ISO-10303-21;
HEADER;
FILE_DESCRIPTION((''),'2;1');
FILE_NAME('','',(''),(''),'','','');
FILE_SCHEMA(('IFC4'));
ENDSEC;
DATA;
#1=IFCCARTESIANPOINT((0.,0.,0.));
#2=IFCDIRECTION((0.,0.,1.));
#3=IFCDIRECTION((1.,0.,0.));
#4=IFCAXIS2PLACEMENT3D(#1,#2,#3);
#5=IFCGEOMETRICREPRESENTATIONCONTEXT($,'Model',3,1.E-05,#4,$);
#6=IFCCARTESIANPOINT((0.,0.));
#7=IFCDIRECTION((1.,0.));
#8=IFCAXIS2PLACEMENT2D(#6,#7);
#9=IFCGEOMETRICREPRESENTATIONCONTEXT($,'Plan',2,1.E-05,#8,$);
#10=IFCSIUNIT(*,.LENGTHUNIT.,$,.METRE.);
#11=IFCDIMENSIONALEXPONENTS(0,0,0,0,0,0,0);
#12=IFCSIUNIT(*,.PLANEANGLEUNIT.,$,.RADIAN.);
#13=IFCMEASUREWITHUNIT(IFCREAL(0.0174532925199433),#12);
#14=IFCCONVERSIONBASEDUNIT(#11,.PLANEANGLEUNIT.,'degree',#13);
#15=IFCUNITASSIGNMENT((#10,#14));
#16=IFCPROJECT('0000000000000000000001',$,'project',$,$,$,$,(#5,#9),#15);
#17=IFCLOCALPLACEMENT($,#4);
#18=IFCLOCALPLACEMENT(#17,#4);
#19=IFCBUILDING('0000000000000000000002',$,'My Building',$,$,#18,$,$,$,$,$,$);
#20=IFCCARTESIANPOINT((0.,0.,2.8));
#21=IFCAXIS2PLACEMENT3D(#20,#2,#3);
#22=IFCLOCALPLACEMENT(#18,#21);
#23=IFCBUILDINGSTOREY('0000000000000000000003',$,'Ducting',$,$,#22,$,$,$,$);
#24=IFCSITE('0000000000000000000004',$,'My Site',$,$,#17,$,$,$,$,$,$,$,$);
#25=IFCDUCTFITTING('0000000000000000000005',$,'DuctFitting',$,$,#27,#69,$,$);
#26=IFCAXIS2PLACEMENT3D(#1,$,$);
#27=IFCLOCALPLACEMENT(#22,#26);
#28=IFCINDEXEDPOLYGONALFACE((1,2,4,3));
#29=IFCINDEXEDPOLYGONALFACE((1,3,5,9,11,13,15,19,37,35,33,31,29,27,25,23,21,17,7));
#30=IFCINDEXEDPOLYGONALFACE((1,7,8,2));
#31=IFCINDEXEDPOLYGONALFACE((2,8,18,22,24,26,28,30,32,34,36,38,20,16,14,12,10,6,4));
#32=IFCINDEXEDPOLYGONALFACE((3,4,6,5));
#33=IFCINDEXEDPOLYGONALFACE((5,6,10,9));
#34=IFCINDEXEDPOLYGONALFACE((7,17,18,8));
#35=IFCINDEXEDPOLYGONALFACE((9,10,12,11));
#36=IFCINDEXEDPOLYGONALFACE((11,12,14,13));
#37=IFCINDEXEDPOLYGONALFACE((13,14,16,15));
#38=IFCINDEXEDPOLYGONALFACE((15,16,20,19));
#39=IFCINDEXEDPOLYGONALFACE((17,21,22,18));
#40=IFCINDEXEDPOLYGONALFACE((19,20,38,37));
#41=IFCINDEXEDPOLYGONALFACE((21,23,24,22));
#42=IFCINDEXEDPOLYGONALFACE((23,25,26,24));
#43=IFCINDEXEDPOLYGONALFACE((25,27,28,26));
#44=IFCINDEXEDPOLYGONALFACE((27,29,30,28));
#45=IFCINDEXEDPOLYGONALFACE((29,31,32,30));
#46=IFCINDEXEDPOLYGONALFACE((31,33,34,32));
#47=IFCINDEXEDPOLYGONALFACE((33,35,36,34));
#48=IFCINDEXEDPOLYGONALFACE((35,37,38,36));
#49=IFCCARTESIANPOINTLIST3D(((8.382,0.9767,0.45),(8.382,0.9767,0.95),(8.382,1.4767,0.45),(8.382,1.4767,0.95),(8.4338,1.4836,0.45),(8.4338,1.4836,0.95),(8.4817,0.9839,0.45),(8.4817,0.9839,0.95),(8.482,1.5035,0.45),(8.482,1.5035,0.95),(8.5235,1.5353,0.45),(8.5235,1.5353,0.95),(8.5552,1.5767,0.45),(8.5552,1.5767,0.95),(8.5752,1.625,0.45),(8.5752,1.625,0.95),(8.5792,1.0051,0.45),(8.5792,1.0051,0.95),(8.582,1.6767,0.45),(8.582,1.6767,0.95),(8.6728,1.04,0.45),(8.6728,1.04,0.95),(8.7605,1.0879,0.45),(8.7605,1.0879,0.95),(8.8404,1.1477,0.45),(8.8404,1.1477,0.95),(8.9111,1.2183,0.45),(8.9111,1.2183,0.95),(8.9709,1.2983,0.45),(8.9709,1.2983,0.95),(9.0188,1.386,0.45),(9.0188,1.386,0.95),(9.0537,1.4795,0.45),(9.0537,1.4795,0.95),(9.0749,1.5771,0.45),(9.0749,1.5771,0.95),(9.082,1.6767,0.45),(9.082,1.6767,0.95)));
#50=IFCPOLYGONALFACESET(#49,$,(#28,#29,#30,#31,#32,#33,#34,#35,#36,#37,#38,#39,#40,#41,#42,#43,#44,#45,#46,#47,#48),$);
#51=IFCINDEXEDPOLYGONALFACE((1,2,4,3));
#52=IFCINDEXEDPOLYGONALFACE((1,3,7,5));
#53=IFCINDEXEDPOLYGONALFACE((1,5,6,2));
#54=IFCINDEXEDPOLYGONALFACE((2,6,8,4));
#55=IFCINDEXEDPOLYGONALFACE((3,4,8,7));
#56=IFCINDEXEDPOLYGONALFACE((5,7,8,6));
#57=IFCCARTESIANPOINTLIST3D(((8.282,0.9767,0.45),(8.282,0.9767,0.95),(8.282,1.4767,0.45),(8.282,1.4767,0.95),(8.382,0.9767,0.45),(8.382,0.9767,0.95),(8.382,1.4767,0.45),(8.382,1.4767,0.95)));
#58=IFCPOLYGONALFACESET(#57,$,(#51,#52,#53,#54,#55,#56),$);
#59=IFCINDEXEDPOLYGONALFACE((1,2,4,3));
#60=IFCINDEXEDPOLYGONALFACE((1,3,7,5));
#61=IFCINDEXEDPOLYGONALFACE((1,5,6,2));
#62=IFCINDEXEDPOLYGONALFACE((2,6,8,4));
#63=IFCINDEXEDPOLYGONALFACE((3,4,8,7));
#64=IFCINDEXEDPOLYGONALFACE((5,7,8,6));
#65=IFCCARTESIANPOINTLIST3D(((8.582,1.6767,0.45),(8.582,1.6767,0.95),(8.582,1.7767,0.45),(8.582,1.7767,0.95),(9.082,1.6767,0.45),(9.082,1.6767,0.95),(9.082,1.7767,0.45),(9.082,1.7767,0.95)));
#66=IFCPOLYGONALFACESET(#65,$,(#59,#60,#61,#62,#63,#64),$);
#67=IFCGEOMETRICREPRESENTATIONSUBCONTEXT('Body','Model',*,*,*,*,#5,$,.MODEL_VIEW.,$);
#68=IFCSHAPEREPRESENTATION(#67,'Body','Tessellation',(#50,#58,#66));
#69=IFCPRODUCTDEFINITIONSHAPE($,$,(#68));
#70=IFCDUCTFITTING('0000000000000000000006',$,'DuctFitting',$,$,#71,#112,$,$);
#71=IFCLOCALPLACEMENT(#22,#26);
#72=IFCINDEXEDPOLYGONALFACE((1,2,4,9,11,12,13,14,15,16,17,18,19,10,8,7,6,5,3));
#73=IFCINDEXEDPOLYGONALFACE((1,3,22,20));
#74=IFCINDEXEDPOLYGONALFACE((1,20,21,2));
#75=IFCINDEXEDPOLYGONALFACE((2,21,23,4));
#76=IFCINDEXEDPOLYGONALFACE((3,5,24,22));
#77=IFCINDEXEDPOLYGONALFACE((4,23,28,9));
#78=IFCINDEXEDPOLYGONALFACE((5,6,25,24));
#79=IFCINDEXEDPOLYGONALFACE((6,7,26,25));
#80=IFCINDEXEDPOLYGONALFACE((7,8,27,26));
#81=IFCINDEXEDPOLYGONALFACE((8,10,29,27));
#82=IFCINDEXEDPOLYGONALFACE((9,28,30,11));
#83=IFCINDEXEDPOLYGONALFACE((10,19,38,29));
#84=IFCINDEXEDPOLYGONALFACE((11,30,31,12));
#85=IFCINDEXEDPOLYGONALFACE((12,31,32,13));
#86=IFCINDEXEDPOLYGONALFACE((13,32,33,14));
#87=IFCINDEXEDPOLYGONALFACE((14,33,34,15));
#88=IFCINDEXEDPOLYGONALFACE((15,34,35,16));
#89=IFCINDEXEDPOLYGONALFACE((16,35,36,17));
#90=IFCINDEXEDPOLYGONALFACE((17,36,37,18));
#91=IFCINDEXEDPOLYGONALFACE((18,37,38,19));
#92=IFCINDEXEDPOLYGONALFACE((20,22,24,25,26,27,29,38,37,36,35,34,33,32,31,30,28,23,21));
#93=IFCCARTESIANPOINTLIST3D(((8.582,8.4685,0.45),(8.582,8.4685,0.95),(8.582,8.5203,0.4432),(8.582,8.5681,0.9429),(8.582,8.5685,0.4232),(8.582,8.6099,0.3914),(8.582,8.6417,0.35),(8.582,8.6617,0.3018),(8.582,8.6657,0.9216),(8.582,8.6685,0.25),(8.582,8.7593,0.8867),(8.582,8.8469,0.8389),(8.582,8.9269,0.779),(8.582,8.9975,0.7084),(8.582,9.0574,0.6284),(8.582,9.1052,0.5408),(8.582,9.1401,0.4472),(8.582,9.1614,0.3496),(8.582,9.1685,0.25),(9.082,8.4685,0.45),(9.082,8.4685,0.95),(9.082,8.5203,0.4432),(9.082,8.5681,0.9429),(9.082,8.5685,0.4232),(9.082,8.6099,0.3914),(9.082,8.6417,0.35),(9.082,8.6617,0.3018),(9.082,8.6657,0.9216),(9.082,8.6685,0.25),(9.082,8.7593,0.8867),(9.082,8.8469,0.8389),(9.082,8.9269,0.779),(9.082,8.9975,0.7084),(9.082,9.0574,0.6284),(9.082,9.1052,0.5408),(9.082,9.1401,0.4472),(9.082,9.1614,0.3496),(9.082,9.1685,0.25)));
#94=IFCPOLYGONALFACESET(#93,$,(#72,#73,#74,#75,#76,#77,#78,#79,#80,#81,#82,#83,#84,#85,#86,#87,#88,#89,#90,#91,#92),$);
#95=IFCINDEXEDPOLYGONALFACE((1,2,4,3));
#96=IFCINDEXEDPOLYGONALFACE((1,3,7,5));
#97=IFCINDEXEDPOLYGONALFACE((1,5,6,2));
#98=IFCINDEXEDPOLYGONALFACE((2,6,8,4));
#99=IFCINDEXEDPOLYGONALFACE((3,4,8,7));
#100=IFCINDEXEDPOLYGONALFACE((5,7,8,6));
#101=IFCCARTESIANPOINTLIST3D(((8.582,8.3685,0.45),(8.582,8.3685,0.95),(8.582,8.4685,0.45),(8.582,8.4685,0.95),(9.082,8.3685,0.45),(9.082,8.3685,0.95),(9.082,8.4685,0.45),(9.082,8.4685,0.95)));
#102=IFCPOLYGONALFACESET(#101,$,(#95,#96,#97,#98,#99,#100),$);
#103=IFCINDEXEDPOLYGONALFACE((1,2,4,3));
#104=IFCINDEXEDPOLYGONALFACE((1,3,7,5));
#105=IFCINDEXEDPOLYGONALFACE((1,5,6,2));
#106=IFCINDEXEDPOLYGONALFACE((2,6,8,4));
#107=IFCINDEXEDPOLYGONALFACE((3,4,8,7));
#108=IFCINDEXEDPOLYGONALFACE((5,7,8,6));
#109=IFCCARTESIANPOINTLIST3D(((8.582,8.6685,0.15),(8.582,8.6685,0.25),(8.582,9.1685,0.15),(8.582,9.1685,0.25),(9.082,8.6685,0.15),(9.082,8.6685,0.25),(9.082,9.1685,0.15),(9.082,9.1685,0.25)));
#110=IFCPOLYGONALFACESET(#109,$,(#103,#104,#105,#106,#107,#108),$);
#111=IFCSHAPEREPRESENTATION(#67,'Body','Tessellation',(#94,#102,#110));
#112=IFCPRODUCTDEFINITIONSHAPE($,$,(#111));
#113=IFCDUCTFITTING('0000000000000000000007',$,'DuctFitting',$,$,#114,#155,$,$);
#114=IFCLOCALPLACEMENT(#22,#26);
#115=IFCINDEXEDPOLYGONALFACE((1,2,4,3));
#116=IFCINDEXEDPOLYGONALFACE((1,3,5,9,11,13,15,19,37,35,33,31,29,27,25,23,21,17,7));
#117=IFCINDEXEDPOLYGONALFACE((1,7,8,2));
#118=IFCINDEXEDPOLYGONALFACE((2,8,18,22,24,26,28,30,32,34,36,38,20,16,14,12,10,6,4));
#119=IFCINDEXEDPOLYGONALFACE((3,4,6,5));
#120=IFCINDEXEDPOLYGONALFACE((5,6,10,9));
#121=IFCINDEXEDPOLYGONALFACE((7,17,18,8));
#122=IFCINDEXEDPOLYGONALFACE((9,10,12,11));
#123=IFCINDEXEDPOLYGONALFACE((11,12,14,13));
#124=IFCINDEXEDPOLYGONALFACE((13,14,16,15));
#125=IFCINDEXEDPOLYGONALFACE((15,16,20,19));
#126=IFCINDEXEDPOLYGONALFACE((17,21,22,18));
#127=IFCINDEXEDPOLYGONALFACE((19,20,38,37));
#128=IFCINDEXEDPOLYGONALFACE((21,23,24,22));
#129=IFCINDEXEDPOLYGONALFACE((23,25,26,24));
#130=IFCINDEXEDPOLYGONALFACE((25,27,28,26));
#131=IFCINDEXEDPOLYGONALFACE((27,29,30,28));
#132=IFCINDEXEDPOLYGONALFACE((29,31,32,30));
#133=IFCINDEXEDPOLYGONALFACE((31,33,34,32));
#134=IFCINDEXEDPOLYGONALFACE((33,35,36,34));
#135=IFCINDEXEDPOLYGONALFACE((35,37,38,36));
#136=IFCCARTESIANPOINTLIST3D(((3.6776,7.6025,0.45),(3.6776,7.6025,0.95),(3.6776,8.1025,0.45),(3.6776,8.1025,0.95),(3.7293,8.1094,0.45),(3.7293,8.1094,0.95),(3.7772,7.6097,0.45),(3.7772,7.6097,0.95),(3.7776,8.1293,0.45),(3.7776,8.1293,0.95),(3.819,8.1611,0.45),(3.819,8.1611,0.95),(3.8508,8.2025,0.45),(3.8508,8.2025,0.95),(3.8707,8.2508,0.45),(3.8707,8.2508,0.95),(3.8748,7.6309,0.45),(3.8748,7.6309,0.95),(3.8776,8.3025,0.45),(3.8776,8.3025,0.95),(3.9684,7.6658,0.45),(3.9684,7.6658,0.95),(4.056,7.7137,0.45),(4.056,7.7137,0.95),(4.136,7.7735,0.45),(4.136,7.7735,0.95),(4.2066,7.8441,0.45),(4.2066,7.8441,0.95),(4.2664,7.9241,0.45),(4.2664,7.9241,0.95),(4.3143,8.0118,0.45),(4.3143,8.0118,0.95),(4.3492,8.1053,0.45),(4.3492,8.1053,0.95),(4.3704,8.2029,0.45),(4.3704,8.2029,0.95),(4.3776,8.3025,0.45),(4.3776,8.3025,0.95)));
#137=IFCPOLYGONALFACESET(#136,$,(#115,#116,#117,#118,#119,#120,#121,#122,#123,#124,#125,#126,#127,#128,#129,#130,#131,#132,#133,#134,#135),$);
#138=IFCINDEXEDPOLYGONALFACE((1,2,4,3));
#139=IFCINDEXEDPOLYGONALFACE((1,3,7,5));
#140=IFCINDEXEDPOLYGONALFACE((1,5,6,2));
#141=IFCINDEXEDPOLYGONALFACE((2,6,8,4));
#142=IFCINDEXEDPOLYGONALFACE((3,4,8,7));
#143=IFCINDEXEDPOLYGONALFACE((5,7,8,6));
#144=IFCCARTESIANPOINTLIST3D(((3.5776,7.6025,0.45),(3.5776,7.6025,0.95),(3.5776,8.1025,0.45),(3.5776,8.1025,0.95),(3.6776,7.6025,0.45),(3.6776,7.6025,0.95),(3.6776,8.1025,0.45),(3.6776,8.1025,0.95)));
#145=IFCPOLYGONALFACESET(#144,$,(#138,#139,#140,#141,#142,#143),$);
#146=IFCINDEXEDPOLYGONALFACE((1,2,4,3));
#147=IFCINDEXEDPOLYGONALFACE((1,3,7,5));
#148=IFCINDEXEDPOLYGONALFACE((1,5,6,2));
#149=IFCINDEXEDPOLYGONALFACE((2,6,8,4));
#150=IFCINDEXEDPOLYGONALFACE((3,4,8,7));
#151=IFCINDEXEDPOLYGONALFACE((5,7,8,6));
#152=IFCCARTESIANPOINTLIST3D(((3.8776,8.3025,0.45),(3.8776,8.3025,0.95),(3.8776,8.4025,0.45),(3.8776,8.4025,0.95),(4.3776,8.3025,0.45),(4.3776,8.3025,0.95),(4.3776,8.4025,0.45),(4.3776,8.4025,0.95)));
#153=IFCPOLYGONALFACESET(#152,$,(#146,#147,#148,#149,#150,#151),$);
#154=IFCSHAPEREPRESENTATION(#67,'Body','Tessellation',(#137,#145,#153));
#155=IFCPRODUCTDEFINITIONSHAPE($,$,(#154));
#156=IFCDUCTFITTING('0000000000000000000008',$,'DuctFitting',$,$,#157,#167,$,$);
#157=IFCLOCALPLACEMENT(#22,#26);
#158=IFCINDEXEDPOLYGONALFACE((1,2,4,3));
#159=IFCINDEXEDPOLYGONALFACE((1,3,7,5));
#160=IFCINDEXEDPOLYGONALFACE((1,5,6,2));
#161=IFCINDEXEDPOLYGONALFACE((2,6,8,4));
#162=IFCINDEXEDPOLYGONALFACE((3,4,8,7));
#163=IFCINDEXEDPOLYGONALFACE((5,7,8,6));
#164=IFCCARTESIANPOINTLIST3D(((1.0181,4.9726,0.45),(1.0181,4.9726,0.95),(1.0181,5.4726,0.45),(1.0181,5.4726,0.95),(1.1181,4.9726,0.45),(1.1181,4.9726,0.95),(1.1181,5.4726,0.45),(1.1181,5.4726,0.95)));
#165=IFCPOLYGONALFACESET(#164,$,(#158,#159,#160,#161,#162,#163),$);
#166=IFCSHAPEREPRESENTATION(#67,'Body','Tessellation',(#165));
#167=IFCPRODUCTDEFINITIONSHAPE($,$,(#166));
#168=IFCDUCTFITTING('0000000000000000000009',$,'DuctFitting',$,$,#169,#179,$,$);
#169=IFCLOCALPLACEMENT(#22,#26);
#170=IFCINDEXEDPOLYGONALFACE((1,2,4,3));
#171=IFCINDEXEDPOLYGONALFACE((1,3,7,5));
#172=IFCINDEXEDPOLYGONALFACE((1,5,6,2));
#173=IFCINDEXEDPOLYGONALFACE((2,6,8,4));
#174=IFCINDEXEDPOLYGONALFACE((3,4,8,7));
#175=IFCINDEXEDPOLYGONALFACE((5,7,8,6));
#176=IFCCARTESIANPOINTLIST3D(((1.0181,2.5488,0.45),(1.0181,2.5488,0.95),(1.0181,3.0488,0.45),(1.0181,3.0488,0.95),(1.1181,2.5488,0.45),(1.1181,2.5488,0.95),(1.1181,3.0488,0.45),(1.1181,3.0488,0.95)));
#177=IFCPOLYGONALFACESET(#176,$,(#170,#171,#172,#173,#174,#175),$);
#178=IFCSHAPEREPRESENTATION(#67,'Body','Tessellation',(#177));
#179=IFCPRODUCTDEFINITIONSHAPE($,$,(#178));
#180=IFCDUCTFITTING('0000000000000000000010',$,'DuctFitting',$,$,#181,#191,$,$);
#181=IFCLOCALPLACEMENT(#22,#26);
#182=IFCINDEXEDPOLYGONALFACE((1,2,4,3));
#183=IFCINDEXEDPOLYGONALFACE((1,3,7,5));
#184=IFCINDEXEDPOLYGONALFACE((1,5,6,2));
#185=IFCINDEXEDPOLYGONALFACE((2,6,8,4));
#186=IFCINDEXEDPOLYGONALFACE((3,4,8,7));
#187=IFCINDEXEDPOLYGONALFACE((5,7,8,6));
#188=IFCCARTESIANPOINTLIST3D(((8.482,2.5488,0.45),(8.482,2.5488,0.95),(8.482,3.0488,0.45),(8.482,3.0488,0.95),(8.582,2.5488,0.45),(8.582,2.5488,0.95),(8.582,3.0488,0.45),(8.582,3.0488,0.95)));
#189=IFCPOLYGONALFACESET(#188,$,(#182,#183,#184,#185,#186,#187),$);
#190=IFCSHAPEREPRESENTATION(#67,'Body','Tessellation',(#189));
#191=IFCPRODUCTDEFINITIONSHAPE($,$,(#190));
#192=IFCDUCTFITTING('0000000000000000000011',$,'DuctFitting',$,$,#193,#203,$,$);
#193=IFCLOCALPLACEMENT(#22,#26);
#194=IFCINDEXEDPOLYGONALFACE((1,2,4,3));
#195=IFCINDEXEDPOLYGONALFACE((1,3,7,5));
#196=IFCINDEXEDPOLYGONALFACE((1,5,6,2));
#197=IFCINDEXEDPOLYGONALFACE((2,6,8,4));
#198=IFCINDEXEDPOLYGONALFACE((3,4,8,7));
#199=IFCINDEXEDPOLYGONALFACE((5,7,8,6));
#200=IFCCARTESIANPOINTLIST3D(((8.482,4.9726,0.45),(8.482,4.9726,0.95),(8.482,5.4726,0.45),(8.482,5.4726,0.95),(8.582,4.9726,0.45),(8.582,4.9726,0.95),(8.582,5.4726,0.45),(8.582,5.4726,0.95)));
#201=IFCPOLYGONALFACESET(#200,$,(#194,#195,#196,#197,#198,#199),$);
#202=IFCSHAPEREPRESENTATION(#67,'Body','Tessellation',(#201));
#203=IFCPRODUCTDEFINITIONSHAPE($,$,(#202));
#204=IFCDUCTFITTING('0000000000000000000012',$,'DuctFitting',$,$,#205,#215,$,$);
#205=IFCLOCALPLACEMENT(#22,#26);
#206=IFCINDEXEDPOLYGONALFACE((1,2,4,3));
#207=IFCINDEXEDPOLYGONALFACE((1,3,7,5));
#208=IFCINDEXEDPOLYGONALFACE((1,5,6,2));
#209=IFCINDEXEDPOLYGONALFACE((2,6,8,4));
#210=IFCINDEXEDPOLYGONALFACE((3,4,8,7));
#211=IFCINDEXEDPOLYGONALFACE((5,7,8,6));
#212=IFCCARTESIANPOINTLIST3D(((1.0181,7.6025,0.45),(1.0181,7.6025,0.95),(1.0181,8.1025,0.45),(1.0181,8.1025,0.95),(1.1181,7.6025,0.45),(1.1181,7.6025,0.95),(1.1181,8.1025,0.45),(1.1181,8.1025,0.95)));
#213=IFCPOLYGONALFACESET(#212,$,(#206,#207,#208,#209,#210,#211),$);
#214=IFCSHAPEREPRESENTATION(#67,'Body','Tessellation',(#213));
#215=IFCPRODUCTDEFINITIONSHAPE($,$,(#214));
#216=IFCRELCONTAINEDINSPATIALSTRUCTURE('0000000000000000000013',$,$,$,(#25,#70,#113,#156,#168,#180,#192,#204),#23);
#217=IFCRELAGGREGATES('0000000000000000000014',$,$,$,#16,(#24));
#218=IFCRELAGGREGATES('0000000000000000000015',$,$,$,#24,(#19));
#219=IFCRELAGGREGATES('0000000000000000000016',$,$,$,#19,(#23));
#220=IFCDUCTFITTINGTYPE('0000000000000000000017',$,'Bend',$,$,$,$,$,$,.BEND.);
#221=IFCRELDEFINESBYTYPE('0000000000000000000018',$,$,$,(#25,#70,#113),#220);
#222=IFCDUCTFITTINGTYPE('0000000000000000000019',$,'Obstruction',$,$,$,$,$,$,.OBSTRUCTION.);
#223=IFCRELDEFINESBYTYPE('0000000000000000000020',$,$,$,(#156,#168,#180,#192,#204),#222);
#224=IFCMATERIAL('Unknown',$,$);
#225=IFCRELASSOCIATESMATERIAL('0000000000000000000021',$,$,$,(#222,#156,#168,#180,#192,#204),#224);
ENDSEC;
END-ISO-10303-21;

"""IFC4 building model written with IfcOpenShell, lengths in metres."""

from ifc_helpers import new_model, entity, si_unit, converted_unit, frame, origin_with_axes, origin_2d_with_axis, place, context, subcontext, project, spatial, line, arc, indexed_curve, rectangle, outline, extrude, source, transform, mapped, material, material_profile, profile_set, profile_usage, type_object, type_shapes, element, save


model = new_model("IFC4")

# Units and contexts
model_context = context("Model", 3, precision=1e-05, world=origin_with_axes())
plan_context = context("Plan", 2, precision=1e-05, world=origin_2d_with_axis())
body_context = subcontext(model_context, "Body", "Model", "MODEL_VIEW")
ifc_project = project(units=[si_unit("LENGTHUNIT", "METRE"), converted_unit("PLANEANGLEUNIT", "degree", entity("IfcReal", 0.0174532925199433), si_unit("PLANEANGLEUNIT", "RADIAN"), dimensions=[0, 0, 0, 0, 0, 0, 0])], contexts=[model_context, plan_context])

# Site, building, storey
site_placement = place(None, origin_with_axes())
site = spatial("IfcSite", under=ifc_project, at=site_placement, Name="My Site")
building_placement = place(site_placement, origin_with_axes())
building = spatial("IfcBuilding", under=site, at=building_placement, Name="My Building")
storey_placement = place(building_placement, frame((0.0, 0.0, 2.8), z_axis=(0.0, 0.0, 1.0), x_axis=(1.0, 0.0, 0.0)))
storey = spatial("IfcBuildingStorey", under=building, at=storey_placement, Name="Ducting")

# Shared definitions
ifc_material = material(Name="Unknown")

# Duct fittings
duct_fitting_type_1 = type_object("IfcDuctFittingType", Name="Bend", PredefinedType="BEND")
shared_shape = source(origin_with_axes(), body_context, "Body", "SweptSolid", [
    extrude(outline(indexed_curve([(0.25, 0.0), (0.3086, -0.1414), (0.45, -0.2), (0.45, -0.7), (-0.045, -0.495), (-0.25, 0.0)], segments=[arc(1, 2, 3), line(3, 4), arc(4, 5, 6), line(6, 1)])), frame((0.0, -0.25, -0.1), z_axis=(0.0, -1.0, 0.0), x_axis=(1.0, 0.0, 0.0)), (0.0, 0.0, -1.0), 0.5),
    extrude(rectangle(XDim=0.5, YDim=0.5), origin_with_axes(), (0.0, 0.0, -1.0), 0.1),
    extrude(rectangle(XDim=0.5, YDim=0.5), frame((0.45, 0.0, -0.55), z_axis=(1.0, 0.0, 0.0), x_axis=(0.0, 0.0, 1.0)), (0.0, 0.0, 1.0), 0.1),
])
type_shapes(duct_fitting_type_1, [shared_shape])
for number, where, z_axis, x_axis, name in (
    (1, (8.282, 1.2267, 0.7), (-1.0, 0.0, -0.000001), (0.0, 1.0, 0.0), "DuctFitting"),
    (2, (8.832, 8.3685, 0.7), (0.0, -1.0, 0.0), (0.0, 0.0, -1.0), "DuctFitting"),
    (3, (3.5776, 7.8525, 0.7), (-1.0, 0.0, 0.000001), (0.0, 1.0, 0.0), "DuctFitting"),
):
    element("IfcDuctFitting", number, at=place(storey_placement, frame(where, z_axis=z_axis, x_axis=x_axis)), inside=storey, type_object=duct_fitting_type_1, Name=name, context=body_context, shape_type="MappedRepresentation", body=[
        mapped(shared_shape, transform((0.0, 0.0, 0.0), x_axis=(1.0, 0.0, 0.0), y_axis=(0.0, 1.0, 0.0), z_axis=(0.0, 0.0, 1.0), scale=1.0)),
    ])
ifc_material_profile_1 = material_profile(ifc_material, rectangle(XDim=0.5, YDim=0.5))
ifc_profile_set_1 = profile_set([ifc_material_profile_1])
ifc_profile_usage_1 = profile_usage(ifc_profile_set_1, cardinal=5)
duct_fitting_type_2 = type_object("IfcDuctFittingType", Name="Obstruction", PredefinedType="OBSTRUCTION", material=ifc_profile_set_1)
duct_fitting_1_placement = place(storey_placement, frame((1.0181, 5.2226, 0.7), z_axis=(1.0, 0.0, 0.0), x_axis=(0.0, 1.0, 0.0)))
element("IfcDuctFitting", 4, at=duct_fitting_1_placement, inside=storey, type_object=duct_fitting_type_2, material=ifc_profile_usage_1, Name="DuctFitting", context=body_context, shape_type="SweptSolid", body=[
    extrude(rectangle(XDim=0.5, YDim=0.5), origin_with_axes(), (0.0, 0.0, 1.0), 0.1),
])
ifc_profile_usage_2 = profile_usage(ifc_profile_set_1, cardinal=5)
duct_fitting_2_placement = place(storey_placement, frame((1.0181, 2.7988, 0.7), z_axis=(1.0, 0.0, 0.0), x_axis=(0.0, 1.0, 0.0)))
element("IfcDuctFitting", 5, at=duct_fitting_2_placement, inside=storey, type_object=duct_fitting_type_2, material=ifc_profile_usage_2, Name="DuctFitting", context=body_context, shape_type="SweptSolid", body=[
    extrude(rectangle(XDim=0.5, YDim=0.5), origin_with_axes(), (0.0, 0.0, 1.0), 0.1),
])
ifc_profile_usage_3 = profile_usage(ifc_profile_set_1, cardinal=5)
duct_fitting_3_placement = place(storey_placement, frame((8.582, 2.7988, 0.7), z_axis=(-1.0, 0.0, 0.0), x_axis=(0.0, -1.0, 0.0)))
element("IfcDuctFitting", 6, at=duct_fitting_3_placement, inside=storey, type_object=duct_fitting_type_2, material=ifc_profile_usage_3, Name="DuctFitting", context=body_context, shape_type="SweptSolid", body=[
    extrude(rectangle(XDim=0.5, YDim=0.5), origin_with_axes(), (0.0, 0.0, 1.0), 0.1),
])
ifc_profile_usage_4 = profile_usage(ifc_profile_set_1, cardinal=5)
duct_fitting_4_placement = place(storey_placement, frame((8.582, 5.2226, 0.7), z_axis=(-1.0, 0.0, 0.0), x_axis=(0.0, -1.0, 0.0)))
element("IfcDuctFitting", 7, at=duct_fitting_4_placement, inside=storey, type_object=duct_fitting_type_2, material=ifc_profile_usage_4, Name="DuctFitting", context=body_context, shape_type="SweptSolid", body=[
    extrude(rectangle(XDim=0.5, YDim=0.5), origin_with_axes(), (0.0, 0.0, 1.0), 0.1),
])
ifc_profile_usage_5 = profile_usage(ifc_profile_set_1, cardinal=5)
duct_fitting_5_placement = place(storey_placement, frame((1.1181, 7.8525, 0.7), z_axis=(-1.0, 0.0, 0.000001), x_axis=(0.0, -1.0, 0.0)))
element("IfcDuctFitting", 8, at=duct_fitting_5_placement, inside=storey, type_object=duct_fitting_type_2, material=ifc_profile_usage_5, Name="DuctFitting", context=body_context, shape_type="SweptSolid", body=[
    extrude(rectangle(XDim=0.5, YDim=0.5), origin_with_axes(), (0.0, 0.0, 1.0), 0.1),
])

save(model, "model.ifc")
